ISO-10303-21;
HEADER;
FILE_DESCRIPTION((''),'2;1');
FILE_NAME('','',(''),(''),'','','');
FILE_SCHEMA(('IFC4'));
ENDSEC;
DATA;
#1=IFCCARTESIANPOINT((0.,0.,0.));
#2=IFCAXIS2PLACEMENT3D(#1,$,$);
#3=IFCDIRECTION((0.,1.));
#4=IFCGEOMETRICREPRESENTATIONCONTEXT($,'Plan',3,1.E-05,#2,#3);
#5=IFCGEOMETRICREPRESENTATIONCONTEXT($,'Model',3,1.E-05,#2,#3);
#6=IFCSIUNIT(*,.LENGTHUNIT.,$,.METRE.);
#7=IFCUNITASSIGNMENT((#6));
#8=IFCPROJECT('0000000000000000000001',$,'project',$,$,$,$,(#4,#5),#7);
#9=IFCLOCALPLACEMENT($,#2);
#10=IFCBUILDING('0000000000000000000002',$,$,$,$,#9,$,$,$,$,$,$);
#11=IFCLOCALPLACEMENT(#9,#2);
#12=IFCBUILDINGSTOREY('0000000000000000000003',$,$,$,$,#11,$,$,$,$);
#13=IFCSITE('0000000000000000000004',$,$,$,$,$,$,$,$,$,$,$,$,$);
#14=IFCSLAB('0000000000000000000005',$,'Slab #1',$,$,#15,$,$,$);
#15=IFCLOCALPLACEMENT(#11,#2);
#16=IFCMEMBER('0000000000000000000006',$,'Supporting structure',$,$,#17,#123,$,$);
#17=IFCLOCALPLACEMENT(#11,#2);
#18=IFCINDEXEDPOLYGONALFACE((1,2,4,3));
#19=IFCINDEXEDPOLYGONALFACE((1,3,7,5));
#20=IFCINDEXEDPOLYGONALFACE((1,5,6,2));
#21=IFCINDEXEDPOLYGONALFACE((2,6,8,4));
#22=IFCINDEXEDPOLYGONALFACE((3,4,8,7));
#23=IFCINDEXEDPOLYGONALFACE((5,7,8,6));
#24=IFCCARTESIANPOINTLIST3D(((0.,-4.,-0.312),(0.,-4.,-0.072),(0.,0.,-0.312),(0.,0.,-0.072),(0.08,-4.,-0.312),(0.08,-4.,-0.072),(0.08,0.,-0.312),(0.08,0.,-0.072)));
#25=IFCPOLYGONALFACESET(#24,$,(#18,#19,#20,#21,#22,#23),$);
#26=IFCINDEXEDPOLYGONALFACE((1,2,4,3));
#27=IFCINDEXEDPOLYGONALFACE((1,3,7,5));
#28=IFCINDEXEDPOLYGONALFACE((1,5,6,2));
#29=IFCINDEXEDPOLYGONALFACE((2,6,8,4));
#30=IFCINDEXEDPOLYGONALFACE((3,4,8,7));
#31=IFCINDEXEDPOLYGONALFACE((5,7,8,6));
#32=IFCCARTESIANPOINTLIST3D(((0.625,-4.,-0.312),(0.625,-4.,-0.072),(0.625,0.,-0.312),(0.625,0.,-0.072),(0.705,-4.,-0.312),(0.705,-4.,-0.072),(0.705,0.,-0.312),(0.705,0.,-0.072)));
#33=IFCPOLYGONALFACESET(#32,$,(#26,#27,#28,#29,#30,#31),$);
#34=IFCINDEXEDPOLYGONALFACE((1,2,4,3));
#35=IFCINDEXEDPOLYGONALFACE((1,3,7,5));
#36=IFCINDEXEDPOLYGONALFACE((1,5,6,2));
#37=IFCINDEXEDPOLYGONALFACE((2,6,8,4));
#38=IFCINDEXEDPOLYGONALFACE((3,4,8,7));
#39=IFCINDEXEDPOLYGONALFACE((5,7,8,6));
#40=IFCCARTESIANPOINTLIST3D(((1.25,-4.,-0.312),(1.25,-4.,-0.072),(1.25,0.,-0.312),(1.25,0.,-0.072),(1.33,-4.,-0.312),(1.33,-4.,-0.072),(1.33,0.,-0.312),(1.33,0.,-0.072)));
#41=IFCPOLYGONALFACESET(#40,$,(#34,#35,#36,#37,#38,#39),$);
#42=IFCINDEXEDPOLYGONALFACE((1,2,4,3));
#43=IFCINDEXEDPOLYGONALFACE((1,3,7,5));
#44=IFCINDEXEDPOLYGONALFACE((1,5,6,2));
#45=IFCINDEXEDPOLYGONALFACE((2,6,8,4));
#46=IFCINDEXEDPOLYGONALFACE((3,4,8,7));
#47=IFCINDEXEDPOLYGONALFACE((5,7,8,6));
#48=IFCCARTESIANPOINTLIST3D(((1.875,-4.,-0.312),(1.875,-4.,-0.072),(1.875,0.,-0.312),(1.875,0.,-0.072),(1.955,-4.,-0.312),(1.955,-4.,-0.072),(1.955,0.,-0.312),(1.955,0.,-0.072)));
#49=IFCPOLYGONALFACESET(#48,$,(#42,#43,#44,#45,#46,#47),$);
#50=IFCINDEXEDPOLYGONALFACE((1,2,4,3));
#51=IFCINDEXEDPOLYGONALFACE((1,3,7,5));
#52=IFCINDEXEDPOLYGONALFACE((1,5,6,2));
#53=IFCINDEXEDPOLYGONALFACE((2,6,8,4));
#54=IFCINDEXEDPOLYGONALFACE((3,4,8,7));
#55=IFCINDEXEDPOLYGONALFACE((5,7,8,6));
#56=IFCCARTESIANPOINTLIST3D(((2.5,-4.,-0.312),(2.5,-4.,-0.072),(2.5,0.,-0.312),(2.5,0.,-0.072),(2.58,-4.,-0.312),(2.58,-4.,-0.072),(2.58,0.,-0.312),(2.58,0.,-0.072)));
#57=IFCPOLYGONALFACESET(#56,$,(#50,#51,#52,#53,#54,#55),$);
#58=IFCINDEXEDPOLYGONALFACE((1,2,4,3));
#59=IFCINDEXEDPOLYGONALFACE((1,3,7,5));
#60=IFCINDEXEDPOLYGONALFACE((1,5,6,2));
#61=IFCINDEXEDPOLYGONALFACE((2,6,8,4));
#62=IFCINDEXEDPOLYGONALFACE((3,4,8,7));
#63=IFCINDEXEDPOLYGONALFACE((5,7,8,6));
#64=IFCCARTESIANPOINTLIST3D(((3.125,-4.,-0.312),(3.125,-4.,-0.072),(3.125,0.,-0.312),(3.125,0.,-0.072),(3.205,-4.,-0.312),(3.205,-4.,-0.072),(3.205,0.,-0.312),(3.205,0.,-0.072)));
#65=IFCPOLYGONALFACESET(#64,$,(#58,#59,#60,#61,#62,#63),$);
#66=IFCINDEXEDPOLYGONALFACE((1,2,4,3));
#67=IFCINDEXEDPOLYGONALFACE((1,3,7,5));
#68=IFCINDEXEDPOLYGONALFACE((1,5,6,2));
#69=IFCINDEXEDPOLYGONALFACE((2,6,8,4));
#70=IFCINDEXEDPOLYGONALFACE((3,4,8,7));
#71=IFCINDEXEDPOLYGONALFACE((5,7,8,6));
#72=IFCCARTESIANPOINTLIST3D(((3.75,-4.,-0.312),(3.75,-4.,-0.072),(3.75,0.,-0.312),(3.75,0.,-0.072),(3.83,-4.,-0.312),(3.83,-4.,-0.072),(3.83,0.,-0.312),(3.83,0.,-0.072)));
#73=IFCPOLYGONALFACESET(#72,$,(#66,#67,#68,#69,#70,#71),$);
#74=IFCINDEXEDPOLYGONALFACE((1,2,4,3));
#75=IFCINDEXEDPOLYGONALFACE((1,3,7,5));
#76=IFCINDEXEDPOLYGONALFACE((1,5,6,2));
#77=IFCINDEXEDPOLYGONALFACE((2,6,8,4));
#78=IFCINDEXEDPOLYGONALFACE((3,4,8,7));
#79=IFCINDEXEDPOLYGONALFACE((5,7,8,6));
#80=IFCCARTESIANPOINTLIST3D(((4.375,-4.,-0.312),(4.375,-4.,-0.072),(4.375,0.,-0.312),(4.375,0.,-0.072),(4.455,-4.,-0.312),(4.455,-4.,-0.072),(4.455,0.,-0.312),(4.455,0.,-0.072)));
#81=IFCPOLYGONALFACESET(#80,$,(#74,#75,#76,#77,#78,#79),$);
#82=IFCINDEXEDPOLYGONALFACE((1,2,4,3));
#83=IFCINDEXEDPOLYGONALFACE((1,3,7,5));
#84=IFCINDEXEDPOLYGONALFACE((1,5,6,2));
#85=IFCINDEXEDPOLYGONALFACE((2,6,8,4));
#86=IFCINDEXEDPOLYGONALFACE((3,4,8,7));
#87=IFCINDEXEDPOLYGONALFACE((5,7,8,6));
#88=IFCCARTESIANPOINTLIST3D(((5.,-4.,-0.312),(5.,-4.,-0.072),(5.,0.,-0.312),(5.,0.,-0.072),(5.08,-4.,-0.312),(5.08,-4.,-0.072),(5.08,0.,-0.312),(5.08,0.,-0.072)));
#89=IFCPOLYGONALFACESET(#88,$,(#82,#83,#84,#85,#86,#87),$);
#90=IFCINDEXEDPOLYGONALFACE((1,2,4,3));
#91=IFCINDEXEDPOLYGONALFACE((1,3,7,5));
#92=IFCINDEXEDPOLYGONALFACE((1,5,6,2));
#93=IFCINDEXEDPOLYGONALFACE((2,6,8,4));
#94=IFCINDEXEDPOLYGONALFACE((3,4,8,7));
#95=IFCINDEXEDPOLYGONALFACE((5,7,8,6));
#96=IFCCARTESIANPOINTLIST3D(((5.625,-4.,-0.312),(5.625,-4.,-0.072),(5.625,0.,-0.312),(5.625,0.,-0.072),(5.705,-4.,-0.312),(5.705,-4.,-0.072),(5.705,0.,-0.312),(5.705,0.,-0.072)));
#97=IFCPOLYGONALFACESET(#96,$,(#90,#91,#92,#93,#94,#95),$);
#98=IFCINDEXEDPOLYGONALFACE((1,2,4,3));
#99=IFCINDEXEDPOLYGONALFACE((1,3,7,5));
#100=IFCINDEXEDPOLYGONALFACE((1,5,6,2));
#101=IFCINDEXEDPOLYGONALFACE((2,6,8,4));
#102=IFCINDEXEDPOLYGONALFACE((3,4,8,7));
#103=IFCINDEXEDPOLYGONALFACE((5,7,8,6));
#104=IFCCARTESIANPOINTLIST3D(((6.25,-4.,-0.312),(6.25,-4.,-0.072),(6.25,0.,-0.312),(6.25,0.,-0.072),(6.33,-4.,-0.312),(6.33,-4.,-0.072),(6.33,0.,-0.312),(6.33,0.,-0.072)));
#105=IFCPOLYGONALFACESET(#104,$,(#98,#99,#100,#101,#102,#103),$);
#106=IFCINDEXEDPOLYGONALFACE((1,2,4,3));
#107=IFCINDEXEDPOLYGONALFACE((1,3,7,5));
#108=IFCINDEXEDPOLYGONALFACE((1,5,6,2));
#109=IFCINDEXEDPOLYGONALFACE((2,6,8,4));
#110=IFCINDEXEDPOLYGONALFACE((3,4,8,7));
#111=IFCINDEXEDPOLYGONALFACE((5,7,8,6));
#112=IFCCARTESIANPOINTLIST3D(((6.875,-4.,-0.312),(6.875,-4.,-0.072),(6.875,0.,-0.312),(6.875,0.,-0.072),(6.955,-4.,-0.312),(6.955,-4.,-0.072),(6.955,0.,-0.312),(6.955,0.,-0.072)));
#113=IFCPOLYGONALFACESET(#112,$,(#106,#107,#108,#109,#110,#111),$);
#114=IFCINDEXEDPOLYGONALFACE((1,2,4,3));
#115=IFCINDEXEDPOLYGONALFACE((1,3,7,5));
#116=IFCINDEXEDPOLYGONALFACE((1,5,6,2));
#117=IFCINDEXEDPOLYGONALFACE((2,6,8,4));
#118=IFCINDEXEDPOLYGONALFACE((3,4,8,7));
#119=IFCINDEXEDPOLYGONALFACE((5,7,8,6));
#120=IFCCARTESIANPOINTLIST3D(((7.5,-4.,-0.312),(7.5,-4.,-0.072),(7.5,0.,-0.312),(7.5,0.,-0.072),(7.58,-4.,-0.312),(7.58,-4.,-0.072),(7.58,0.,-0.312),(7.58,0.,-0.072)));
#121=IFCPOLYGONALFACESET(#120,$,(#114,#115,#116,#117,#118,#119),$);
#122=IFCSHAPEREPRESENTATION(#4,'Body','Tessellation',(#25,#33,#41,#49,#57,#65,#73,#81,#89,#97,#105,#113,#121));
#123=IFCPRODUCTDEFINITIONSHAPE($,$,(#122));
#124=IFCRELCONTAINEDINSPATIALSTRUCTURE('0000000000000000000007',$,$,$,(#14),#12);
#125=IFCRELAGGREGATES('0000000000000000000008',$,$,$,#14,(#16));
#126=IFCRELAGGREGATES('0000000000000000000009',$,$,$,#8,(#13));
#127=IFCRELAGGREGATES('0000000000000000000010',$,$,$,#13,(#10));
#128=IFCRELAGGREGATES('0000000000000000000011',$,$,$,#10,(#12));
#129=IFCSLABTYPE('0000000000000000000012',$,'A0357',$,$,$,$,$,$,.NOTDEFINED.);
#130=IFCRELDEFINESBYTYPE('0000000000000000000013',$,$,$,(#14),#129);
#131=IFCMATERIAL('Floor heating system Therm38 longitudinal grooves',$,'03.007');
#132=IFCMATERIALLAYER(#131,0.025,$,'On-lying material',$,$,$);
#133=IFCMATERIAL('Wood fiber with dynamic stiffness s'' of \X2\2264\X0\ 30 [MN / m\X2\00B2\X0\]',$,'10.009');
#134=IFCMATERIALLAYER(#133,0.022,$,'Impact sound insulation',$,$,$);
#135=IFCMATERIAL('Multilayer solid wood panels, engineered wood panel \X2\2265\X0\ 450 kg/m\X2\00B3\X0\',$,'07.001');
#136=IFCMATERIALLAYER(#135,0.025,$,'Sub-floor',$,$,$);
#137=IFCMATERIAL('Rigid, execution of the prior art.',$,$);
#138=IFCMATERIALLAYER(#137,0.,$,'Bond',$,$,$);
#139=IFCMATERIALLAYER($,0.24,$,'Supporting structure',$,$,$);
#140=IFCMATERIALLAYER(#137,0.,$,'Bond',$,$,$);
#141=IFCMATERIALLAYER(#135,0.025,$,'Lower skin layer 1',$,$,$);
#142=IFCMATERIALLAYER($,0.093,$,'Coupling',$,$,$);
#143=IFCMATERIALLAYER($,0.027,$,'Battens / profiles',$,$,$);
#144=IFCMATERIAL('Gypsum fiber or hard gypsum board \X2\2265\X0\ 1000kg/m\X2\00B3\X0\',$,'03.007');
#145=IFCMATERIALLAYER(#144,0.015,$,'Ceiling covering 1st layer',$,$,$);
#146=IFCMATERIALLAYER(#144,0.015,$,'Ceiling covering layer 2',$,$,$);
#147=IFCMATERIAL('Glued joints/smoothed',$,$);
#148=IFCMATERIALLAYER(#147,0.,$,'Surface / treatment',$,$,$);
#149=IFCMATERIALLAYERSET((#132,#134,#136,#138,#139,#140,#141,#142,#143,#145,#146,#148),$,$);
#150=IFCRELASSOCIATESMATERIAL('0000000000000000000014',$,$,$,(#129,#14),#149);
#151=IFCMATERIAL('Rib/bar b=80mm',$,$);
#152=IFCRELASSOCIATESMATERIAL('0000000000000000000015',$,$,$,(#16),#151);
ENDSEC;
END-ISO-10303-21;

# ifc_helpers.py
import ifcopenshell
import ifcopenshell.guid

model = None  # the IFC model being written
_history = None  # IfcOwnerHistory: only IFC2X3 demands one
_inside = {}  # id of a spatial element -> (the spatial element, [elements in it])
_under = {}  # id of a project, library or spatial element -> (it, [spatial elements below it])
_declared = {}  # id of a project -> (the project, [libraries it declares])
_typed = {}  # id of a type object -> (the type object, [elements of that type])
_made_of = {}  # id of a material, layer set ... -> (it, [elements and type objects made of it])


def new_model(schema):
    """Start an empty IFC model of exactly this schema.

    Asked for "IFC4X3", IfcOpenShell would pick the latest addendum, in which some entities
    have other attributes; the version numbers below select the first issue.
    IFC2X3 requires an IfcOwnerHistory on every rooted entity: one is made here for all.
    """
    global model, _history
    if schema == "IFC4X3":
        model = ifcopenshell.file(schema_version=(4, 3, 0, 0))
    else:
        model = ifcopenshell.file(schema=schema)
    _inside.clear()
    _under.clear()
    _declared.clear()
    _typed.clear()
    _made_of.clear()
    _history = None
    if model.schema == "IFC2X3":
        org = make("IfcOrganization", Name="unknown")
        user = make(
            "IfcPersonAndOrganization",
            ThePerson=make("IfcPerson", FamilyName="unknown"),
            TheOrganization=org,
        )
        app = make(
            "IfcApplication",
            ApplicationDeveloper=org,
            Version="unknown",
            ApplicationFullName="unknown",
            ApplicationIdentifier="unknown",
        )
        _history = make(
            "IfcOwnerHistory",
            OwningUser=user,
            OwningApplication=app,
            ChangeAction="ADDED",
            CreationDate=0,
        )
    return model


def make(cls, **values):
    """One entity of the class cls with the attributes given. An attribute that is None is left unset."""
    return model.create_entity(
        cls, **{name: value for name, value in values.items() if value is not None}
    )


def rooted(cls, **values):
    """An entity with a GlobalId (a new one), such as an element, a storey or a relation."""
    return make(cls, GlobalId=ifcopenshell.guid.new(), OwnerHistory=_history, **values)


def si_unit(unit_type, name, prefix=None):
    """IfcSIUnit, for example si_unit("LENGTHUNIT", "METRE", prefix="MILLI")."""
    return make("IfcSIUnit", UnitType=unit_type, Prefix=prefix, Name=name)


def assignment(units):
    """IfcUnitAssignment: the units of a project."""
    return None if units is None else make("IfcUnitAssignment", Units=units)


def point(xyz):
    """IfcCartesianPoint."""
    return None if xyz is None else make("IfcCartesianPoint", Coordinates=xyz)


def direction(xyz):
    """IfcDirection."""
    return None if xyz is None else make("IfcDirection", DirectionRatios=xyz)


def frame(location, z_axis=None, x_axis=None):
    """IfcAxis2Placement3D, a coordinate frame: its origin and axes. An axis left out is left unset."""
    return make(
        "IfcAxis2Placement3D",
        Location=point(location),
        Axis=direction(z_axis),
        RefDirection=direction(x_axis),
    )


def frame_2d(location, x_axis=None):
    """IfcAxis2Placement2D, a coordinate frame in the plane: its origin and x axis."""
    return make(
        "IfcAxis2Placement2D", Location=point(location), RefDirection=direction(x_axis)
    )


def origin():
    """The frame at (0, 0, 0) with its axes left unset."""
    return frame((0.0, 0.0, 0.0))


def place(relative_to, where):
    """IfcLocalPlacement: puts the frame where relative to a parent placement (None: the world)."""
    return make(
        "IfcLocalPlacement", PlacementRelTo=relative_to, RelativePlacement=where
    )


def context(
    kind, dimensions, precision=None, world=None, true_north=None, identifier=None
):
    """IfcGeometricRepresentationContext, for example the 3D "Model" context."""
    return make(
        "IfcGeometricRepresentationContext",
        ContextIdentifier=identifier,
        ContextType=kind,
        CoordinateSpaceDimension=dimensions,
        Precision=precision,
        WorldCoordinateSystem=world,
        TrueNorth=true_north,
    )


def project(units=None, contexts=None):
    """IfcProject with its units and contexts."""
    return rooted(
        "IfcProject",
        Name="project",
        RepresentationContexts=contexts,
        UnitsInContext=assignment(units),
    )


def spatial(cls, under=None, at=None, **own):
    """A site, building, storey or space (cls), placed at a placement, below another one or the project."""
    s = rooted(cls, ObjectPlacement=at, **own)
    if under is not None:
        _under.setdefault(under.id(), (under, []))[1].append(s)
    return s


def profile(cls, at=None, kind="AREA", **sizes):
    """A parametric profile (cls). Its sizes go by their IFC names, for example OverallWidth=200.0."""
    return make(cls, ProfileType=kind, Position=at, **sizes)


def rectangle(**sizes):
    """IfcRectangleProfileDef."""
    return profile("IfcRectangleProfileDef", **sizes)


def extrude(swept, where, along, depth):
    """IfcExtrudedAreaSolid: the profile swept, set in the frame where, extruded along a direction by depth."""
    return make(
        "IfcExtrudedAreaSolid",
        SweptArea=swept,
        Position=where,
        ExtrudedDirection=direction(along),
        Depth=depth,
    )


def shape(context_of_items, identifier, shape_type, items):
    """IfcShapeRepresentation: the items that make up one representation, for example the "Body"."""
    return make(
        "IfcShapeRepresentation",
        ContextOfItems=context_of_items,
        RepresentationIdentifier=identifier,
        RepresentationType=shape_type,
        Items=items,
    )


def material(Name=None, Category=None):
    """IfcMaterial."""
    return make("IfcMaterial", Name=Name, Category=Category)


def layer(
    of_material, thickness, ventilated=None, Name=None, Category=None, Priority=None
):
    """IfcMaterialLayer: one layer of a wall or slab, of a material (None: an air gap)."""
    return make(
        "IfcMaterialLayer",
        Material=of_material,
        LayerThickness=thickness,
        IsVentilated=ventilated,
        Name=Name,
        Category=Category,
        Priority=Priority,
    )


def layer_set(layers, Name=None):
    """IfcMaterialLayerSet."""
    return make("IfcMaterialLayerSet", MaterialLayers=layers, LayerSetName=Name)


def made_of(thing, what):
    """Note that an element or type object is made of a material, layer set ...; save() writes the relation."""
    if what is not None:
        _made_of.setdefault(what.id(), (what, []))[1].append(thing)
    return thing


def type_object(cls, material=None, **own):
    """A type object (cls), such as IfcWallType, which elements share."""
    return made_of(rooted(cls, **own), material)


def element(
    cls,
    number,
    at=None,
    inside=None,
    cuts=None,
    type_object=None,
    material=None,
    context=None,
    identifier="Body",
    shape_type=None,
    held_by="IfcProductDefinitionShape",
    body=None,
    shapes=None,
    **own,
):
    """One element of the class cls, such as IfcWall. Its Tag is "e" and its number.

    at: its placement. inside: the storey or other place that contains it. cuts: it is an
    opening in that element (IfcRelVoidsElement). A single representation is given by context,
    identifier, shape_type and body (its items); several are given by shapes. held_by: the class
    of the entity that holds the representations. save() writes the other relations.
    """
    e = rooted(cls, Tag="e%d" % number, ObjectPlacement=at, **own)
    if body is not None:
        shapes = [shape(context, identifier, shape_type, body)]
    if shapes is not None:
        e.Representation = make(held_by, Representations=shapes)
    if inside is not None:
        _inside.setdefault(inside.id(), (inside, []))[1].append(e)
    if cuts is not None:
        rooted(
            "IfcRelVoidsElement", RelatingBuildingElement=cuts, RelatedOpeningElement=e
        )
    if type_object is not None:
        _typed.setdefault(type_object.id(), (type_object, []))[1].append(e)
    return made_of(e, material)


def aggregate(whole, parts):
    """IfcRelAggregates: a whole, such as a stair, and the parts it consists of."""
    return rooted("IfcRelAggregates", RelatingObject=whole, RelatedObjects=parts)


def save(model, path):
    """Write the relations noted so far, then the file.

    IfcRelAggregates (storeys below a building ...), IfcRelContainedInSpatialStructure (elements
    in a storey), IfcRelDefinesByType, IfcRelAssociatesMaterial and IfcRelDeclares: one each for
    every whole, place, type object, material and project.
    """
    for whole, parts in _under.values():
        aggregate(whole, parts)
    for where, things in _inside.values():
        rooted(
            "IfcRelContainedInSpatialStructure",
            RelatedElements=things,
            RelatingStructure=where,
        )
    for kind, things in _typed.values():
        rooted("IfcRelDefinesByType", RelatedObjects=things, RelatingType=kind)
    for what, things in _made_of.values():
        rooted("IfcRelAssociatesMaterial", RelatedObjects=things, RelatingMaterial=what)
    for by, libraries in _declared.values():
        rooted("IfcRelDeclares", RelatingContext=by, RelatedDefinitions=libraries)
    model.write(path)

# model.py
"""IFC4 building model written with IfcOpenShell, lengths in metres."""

from ifc_helpers import new_model, si_unit, direction, frame, frame_2d, origin, place, context, project, spatial, rectangle, extrude, material, layer, layer_set, type_object, element, aggregate, save


model = new_model("IFC4")

# Units and contexts
plan_context = context("Plan", 3, precision=1e-05, world=origin(), true_north=direction((0.0, 1.0)))
model_context = context("Model", 3, precision=1e-05, world=origin(), true_north=direction((0.0, 1.0)))
ifc_project = project(units=[si_unit("LENGTHUNIT", "METRE")], contexts=[plan_context, model_context])

# Site, building, storey
site = spatial("IfcSite", under=ifc_project)
building_placement = place(None, origin())
building = spatial("IfcBuilding", under=site, at=building_placement)
storey_placement = place(building_placement, origin())
storey = spatial("IfcBuildingStorey", under=building, at=storey_placement)

# Slab, member
ifc_material_1 = material(Name="Floor heating system Therm38 longitudinal grooves", Category="03.007")
ifc_layer_1 = layer(ifc_material_1, 0.025, Name="On-lying material")
ifc_material_2 = material(Name="Wood fiber with dynamic stiffness s' of ≤ 30 [MN / m²]", Category="10.009")
ifc_layer_2 = layer(ifc_material_2, 0.022, Name="Impact sound insulation")
ifc_material_3 = material(Name="Multilayer solid wood panels, engineered wood panel ≥ 450 kg/m³", Category="07.001")
ifc_layer_3 = layer(ifc_material_3, 0.025, Name="Sub-floor")
ifc_material_4 = material(Name="Rigid, execution of the prior art.")
ifc_layer_4 = layer(ifc_material_4, 0.0, Name="Bond")
ifc_layer_5 = layer(None, 0.24, Name="Supporting structure")
ifc_layer_6 = layer(ifc_material_4, 0.0, Name="Bond")
ifc_layer_7 = layer(ifc_material_3, 0.025, Name="Lower skin layer 1")
ifc_layer_8 = layer(None, 0.093, Name="Coupling")
ifc_layer_9 = layer(None, 0.027, Name="Battens / profiles")
ifc_material_5 = material(Name="Gypsum fiber or hard gypsum board ≥ 1000kg/m³", Category="03.007")
ifc_layer_10 = layer(ifc_material_5, 0.015, Name="Ceiling covering 1st layer")
ifc_layer_11 = layer(ifc_material_5, 0.015, Name="Ceiling covering layer 2")
ifc_material_6 = material(Name="Glued joints/smoothed")
ifc_layer_12 = layer(ifc_material_6, 0.0, Name="Surface / treatment")
ifc_layer_set = layer_set([ifc_layer_1, ifc_layer_2, ifc_layer_3, ifc_layer_4, ifc_layer_5, ifc_layer_6, ifc_layer_7, ifc_layer_8, ifc_layer_9, ifc_layer_10, ifc_layer_11, ifc_layer_12])
slab_type = type_object("IfcSlabType", Name="A0357", PredefinedType="NOTDEFINED", material=ifc_layer_set)
slab_placement = place(None, frame((0.0, 0.0, 0.0), z_axis=(0.0, 0.0, -1.0), x_axis=(1.0, 0.0, 0.0)))
slab = element("IfcSlab", 1, at=slab_placement, inside=storey, type_object=slab_type, material=ifc_layer_set, Name="Slab #1")
ifc_material_7 = material(Name="Rib/bar b=80mm")
member_1_placement = place(slab_placement, origin())
member_1 = element("IfcMember", 2, at=member_1_placement, material=ifc_material_7, Name="Supporting structure", context=plan_context, shape_type="SweptSolid", body=[
    extrude(rectangle(XDim=0.08, YDim=0.24, at=frame_2d((0.04, 0.12), x_axis=(1.0, 0.0))), frame((0.0, 4.0, 0.072), z_axis=(0.0, -1.0, 0.0), x_axis=(1.0, 0.0, 0.0)), (0.0, 0.0, 1.0), 4.0),
    extrude(rectangle(XDim=0.08, YDim=0.24, at=frame_2d((0.04, 0.12), x_axis=(1.0, 0.0))), frame((0.625, 4.0, 0.072), z_axis=(0.0, -1.0, 0.0), x_axis=(1.0, 0.0, 0.0)), (0.0, 0.0, 1.0), 4.0),
    extrude(rectangle(XDim=0.08, YDim=0.24, at=frame_2d((0.04, 0.12), x_axis=(1.0, 0.0))), frame((1.25, 4.0, 0.072), z_axis=(0.0, -1.0, 0.0), x_axis=(1.0, 0.0, 0.0)), (0.0, 0.0, 1.0), 4.0),
    extrude(rectangle(XDim=0.08, YDim=0.24, at=frame_2d((0.04, 0.12), x_axis=(1.0, 0.0))), frame((1.875, 4.0, 0.072), z_axis=(0.0, -1.0, 0.0), x_axis=(1.0, 0.0, 0.0)), (0.0, 0.0, 1.0), 4.0),
    extrude(rectangle(XDim=0.08, YDim=0.24, at=frame_2d((0.04, 0.12), x_axis=(1.0, 0.0))), frame((2.5, 4.0, 0.072), z_axis=(0.0, -1.0, 0.0), x_axis=(1.0, 0.0, 0.0)), (0.0, 0.0, 1.0), 4.0),
    extrude(rectangle(XDim=0.08, YDim=0.24, at=frame_2d((0.04, 0.12), x_axis=(1.0, 0.0))), frame((3.125, 4.0, 0.072), z_axis=(0.0, -1.0, 0.0), x_axis=(1.0, 0.0, 0.0)), (0.0, 0.0, 1.0), 4.0),
    extrude(rectangle(XDim=0.08, YDim=0.24, at=frame_2d((0.04, 0.12), x_axis=(1.0, 0.0))), frame((3.75, 4.0, 0.072), z_axis=(0.0, -1.0, 0.0), x_axis=(1.0, 0.0, 0.0)), (0.0, 0.0, 1.0), 4.0),
    extrude(rectangle(XDim=0.08, YDim=0.24, at=frame_2d((0.04, 0.12), x_axis=(1.0, 0.0))), frame((4.375, 4.0, 0.072), z_axis=(0.0, -1.0, 0.0), x_axis=(1.0, 0.0, 0.0)), (0.0, 0.0, 1.0), 4.0),
    extrude(rectangle(XDim=0.08, YDim=0.24, at=frame_2d((0.04, 0.12), x_axis=(1.0, 0.0))), frame((5.0, 4.0, 0.072), z_axis=(0.0, -1.0, 0.0), x_axis=(1.0, 0.0, 0.0)), (0.0, 0.0, 1.0), 4.0),
    extrude(rectangle(XDim=0.08, YDim=0.24, at=frame_2d((0.04, 0.12), x_axis=(1.0, 0.0))), frame((5.625, 4.0, 0.072), z_axis=(0.0, -1.0, 0.0), x_axis=(1.0, 0.0, 0.0)), (0.0, 0.0, 1.0), 4.0),
    extrude(rectangle(XDim=0.08, YDim=0.24, at=frame_2d((0.04, 0.12), x_axis=(1.0, 0.0))), frame((6.25, 4.0, 0.072), z_axis=(0.0, -1.0, 0.0), x_axis=(1.0, 0.0, 0.0)), (0.0, 0.0, 1.0), 4.0),
    extrude(rectangle(XDim=0.08, YDim=0.24, at=frame_2d((0.04, 0.12), x_axis=(1.0, 0.0))), frame((6.875, 4.0, 0.072), z_axis=(0.0, -1.0, 0.0), x_axis=(1.0, 0.0, 0.0)), (0.0, 0.0, 1.0), 4.0),
    extrude(rectangle(XDim=0.08, YDim=0.24, at=frame_2d((0.04, 0.12), x_axis=(1.0, 0.0))), frame((7.5, 4.0, 0.072), z_axis=(0.0, -1.0, 0.0), x_axis=(1.0, 0.0, 0.0)), (0.0, 0.0, 1.0), 4.0),
])
aggregate(slab, [member_1])

save(model, "model.ifc")
